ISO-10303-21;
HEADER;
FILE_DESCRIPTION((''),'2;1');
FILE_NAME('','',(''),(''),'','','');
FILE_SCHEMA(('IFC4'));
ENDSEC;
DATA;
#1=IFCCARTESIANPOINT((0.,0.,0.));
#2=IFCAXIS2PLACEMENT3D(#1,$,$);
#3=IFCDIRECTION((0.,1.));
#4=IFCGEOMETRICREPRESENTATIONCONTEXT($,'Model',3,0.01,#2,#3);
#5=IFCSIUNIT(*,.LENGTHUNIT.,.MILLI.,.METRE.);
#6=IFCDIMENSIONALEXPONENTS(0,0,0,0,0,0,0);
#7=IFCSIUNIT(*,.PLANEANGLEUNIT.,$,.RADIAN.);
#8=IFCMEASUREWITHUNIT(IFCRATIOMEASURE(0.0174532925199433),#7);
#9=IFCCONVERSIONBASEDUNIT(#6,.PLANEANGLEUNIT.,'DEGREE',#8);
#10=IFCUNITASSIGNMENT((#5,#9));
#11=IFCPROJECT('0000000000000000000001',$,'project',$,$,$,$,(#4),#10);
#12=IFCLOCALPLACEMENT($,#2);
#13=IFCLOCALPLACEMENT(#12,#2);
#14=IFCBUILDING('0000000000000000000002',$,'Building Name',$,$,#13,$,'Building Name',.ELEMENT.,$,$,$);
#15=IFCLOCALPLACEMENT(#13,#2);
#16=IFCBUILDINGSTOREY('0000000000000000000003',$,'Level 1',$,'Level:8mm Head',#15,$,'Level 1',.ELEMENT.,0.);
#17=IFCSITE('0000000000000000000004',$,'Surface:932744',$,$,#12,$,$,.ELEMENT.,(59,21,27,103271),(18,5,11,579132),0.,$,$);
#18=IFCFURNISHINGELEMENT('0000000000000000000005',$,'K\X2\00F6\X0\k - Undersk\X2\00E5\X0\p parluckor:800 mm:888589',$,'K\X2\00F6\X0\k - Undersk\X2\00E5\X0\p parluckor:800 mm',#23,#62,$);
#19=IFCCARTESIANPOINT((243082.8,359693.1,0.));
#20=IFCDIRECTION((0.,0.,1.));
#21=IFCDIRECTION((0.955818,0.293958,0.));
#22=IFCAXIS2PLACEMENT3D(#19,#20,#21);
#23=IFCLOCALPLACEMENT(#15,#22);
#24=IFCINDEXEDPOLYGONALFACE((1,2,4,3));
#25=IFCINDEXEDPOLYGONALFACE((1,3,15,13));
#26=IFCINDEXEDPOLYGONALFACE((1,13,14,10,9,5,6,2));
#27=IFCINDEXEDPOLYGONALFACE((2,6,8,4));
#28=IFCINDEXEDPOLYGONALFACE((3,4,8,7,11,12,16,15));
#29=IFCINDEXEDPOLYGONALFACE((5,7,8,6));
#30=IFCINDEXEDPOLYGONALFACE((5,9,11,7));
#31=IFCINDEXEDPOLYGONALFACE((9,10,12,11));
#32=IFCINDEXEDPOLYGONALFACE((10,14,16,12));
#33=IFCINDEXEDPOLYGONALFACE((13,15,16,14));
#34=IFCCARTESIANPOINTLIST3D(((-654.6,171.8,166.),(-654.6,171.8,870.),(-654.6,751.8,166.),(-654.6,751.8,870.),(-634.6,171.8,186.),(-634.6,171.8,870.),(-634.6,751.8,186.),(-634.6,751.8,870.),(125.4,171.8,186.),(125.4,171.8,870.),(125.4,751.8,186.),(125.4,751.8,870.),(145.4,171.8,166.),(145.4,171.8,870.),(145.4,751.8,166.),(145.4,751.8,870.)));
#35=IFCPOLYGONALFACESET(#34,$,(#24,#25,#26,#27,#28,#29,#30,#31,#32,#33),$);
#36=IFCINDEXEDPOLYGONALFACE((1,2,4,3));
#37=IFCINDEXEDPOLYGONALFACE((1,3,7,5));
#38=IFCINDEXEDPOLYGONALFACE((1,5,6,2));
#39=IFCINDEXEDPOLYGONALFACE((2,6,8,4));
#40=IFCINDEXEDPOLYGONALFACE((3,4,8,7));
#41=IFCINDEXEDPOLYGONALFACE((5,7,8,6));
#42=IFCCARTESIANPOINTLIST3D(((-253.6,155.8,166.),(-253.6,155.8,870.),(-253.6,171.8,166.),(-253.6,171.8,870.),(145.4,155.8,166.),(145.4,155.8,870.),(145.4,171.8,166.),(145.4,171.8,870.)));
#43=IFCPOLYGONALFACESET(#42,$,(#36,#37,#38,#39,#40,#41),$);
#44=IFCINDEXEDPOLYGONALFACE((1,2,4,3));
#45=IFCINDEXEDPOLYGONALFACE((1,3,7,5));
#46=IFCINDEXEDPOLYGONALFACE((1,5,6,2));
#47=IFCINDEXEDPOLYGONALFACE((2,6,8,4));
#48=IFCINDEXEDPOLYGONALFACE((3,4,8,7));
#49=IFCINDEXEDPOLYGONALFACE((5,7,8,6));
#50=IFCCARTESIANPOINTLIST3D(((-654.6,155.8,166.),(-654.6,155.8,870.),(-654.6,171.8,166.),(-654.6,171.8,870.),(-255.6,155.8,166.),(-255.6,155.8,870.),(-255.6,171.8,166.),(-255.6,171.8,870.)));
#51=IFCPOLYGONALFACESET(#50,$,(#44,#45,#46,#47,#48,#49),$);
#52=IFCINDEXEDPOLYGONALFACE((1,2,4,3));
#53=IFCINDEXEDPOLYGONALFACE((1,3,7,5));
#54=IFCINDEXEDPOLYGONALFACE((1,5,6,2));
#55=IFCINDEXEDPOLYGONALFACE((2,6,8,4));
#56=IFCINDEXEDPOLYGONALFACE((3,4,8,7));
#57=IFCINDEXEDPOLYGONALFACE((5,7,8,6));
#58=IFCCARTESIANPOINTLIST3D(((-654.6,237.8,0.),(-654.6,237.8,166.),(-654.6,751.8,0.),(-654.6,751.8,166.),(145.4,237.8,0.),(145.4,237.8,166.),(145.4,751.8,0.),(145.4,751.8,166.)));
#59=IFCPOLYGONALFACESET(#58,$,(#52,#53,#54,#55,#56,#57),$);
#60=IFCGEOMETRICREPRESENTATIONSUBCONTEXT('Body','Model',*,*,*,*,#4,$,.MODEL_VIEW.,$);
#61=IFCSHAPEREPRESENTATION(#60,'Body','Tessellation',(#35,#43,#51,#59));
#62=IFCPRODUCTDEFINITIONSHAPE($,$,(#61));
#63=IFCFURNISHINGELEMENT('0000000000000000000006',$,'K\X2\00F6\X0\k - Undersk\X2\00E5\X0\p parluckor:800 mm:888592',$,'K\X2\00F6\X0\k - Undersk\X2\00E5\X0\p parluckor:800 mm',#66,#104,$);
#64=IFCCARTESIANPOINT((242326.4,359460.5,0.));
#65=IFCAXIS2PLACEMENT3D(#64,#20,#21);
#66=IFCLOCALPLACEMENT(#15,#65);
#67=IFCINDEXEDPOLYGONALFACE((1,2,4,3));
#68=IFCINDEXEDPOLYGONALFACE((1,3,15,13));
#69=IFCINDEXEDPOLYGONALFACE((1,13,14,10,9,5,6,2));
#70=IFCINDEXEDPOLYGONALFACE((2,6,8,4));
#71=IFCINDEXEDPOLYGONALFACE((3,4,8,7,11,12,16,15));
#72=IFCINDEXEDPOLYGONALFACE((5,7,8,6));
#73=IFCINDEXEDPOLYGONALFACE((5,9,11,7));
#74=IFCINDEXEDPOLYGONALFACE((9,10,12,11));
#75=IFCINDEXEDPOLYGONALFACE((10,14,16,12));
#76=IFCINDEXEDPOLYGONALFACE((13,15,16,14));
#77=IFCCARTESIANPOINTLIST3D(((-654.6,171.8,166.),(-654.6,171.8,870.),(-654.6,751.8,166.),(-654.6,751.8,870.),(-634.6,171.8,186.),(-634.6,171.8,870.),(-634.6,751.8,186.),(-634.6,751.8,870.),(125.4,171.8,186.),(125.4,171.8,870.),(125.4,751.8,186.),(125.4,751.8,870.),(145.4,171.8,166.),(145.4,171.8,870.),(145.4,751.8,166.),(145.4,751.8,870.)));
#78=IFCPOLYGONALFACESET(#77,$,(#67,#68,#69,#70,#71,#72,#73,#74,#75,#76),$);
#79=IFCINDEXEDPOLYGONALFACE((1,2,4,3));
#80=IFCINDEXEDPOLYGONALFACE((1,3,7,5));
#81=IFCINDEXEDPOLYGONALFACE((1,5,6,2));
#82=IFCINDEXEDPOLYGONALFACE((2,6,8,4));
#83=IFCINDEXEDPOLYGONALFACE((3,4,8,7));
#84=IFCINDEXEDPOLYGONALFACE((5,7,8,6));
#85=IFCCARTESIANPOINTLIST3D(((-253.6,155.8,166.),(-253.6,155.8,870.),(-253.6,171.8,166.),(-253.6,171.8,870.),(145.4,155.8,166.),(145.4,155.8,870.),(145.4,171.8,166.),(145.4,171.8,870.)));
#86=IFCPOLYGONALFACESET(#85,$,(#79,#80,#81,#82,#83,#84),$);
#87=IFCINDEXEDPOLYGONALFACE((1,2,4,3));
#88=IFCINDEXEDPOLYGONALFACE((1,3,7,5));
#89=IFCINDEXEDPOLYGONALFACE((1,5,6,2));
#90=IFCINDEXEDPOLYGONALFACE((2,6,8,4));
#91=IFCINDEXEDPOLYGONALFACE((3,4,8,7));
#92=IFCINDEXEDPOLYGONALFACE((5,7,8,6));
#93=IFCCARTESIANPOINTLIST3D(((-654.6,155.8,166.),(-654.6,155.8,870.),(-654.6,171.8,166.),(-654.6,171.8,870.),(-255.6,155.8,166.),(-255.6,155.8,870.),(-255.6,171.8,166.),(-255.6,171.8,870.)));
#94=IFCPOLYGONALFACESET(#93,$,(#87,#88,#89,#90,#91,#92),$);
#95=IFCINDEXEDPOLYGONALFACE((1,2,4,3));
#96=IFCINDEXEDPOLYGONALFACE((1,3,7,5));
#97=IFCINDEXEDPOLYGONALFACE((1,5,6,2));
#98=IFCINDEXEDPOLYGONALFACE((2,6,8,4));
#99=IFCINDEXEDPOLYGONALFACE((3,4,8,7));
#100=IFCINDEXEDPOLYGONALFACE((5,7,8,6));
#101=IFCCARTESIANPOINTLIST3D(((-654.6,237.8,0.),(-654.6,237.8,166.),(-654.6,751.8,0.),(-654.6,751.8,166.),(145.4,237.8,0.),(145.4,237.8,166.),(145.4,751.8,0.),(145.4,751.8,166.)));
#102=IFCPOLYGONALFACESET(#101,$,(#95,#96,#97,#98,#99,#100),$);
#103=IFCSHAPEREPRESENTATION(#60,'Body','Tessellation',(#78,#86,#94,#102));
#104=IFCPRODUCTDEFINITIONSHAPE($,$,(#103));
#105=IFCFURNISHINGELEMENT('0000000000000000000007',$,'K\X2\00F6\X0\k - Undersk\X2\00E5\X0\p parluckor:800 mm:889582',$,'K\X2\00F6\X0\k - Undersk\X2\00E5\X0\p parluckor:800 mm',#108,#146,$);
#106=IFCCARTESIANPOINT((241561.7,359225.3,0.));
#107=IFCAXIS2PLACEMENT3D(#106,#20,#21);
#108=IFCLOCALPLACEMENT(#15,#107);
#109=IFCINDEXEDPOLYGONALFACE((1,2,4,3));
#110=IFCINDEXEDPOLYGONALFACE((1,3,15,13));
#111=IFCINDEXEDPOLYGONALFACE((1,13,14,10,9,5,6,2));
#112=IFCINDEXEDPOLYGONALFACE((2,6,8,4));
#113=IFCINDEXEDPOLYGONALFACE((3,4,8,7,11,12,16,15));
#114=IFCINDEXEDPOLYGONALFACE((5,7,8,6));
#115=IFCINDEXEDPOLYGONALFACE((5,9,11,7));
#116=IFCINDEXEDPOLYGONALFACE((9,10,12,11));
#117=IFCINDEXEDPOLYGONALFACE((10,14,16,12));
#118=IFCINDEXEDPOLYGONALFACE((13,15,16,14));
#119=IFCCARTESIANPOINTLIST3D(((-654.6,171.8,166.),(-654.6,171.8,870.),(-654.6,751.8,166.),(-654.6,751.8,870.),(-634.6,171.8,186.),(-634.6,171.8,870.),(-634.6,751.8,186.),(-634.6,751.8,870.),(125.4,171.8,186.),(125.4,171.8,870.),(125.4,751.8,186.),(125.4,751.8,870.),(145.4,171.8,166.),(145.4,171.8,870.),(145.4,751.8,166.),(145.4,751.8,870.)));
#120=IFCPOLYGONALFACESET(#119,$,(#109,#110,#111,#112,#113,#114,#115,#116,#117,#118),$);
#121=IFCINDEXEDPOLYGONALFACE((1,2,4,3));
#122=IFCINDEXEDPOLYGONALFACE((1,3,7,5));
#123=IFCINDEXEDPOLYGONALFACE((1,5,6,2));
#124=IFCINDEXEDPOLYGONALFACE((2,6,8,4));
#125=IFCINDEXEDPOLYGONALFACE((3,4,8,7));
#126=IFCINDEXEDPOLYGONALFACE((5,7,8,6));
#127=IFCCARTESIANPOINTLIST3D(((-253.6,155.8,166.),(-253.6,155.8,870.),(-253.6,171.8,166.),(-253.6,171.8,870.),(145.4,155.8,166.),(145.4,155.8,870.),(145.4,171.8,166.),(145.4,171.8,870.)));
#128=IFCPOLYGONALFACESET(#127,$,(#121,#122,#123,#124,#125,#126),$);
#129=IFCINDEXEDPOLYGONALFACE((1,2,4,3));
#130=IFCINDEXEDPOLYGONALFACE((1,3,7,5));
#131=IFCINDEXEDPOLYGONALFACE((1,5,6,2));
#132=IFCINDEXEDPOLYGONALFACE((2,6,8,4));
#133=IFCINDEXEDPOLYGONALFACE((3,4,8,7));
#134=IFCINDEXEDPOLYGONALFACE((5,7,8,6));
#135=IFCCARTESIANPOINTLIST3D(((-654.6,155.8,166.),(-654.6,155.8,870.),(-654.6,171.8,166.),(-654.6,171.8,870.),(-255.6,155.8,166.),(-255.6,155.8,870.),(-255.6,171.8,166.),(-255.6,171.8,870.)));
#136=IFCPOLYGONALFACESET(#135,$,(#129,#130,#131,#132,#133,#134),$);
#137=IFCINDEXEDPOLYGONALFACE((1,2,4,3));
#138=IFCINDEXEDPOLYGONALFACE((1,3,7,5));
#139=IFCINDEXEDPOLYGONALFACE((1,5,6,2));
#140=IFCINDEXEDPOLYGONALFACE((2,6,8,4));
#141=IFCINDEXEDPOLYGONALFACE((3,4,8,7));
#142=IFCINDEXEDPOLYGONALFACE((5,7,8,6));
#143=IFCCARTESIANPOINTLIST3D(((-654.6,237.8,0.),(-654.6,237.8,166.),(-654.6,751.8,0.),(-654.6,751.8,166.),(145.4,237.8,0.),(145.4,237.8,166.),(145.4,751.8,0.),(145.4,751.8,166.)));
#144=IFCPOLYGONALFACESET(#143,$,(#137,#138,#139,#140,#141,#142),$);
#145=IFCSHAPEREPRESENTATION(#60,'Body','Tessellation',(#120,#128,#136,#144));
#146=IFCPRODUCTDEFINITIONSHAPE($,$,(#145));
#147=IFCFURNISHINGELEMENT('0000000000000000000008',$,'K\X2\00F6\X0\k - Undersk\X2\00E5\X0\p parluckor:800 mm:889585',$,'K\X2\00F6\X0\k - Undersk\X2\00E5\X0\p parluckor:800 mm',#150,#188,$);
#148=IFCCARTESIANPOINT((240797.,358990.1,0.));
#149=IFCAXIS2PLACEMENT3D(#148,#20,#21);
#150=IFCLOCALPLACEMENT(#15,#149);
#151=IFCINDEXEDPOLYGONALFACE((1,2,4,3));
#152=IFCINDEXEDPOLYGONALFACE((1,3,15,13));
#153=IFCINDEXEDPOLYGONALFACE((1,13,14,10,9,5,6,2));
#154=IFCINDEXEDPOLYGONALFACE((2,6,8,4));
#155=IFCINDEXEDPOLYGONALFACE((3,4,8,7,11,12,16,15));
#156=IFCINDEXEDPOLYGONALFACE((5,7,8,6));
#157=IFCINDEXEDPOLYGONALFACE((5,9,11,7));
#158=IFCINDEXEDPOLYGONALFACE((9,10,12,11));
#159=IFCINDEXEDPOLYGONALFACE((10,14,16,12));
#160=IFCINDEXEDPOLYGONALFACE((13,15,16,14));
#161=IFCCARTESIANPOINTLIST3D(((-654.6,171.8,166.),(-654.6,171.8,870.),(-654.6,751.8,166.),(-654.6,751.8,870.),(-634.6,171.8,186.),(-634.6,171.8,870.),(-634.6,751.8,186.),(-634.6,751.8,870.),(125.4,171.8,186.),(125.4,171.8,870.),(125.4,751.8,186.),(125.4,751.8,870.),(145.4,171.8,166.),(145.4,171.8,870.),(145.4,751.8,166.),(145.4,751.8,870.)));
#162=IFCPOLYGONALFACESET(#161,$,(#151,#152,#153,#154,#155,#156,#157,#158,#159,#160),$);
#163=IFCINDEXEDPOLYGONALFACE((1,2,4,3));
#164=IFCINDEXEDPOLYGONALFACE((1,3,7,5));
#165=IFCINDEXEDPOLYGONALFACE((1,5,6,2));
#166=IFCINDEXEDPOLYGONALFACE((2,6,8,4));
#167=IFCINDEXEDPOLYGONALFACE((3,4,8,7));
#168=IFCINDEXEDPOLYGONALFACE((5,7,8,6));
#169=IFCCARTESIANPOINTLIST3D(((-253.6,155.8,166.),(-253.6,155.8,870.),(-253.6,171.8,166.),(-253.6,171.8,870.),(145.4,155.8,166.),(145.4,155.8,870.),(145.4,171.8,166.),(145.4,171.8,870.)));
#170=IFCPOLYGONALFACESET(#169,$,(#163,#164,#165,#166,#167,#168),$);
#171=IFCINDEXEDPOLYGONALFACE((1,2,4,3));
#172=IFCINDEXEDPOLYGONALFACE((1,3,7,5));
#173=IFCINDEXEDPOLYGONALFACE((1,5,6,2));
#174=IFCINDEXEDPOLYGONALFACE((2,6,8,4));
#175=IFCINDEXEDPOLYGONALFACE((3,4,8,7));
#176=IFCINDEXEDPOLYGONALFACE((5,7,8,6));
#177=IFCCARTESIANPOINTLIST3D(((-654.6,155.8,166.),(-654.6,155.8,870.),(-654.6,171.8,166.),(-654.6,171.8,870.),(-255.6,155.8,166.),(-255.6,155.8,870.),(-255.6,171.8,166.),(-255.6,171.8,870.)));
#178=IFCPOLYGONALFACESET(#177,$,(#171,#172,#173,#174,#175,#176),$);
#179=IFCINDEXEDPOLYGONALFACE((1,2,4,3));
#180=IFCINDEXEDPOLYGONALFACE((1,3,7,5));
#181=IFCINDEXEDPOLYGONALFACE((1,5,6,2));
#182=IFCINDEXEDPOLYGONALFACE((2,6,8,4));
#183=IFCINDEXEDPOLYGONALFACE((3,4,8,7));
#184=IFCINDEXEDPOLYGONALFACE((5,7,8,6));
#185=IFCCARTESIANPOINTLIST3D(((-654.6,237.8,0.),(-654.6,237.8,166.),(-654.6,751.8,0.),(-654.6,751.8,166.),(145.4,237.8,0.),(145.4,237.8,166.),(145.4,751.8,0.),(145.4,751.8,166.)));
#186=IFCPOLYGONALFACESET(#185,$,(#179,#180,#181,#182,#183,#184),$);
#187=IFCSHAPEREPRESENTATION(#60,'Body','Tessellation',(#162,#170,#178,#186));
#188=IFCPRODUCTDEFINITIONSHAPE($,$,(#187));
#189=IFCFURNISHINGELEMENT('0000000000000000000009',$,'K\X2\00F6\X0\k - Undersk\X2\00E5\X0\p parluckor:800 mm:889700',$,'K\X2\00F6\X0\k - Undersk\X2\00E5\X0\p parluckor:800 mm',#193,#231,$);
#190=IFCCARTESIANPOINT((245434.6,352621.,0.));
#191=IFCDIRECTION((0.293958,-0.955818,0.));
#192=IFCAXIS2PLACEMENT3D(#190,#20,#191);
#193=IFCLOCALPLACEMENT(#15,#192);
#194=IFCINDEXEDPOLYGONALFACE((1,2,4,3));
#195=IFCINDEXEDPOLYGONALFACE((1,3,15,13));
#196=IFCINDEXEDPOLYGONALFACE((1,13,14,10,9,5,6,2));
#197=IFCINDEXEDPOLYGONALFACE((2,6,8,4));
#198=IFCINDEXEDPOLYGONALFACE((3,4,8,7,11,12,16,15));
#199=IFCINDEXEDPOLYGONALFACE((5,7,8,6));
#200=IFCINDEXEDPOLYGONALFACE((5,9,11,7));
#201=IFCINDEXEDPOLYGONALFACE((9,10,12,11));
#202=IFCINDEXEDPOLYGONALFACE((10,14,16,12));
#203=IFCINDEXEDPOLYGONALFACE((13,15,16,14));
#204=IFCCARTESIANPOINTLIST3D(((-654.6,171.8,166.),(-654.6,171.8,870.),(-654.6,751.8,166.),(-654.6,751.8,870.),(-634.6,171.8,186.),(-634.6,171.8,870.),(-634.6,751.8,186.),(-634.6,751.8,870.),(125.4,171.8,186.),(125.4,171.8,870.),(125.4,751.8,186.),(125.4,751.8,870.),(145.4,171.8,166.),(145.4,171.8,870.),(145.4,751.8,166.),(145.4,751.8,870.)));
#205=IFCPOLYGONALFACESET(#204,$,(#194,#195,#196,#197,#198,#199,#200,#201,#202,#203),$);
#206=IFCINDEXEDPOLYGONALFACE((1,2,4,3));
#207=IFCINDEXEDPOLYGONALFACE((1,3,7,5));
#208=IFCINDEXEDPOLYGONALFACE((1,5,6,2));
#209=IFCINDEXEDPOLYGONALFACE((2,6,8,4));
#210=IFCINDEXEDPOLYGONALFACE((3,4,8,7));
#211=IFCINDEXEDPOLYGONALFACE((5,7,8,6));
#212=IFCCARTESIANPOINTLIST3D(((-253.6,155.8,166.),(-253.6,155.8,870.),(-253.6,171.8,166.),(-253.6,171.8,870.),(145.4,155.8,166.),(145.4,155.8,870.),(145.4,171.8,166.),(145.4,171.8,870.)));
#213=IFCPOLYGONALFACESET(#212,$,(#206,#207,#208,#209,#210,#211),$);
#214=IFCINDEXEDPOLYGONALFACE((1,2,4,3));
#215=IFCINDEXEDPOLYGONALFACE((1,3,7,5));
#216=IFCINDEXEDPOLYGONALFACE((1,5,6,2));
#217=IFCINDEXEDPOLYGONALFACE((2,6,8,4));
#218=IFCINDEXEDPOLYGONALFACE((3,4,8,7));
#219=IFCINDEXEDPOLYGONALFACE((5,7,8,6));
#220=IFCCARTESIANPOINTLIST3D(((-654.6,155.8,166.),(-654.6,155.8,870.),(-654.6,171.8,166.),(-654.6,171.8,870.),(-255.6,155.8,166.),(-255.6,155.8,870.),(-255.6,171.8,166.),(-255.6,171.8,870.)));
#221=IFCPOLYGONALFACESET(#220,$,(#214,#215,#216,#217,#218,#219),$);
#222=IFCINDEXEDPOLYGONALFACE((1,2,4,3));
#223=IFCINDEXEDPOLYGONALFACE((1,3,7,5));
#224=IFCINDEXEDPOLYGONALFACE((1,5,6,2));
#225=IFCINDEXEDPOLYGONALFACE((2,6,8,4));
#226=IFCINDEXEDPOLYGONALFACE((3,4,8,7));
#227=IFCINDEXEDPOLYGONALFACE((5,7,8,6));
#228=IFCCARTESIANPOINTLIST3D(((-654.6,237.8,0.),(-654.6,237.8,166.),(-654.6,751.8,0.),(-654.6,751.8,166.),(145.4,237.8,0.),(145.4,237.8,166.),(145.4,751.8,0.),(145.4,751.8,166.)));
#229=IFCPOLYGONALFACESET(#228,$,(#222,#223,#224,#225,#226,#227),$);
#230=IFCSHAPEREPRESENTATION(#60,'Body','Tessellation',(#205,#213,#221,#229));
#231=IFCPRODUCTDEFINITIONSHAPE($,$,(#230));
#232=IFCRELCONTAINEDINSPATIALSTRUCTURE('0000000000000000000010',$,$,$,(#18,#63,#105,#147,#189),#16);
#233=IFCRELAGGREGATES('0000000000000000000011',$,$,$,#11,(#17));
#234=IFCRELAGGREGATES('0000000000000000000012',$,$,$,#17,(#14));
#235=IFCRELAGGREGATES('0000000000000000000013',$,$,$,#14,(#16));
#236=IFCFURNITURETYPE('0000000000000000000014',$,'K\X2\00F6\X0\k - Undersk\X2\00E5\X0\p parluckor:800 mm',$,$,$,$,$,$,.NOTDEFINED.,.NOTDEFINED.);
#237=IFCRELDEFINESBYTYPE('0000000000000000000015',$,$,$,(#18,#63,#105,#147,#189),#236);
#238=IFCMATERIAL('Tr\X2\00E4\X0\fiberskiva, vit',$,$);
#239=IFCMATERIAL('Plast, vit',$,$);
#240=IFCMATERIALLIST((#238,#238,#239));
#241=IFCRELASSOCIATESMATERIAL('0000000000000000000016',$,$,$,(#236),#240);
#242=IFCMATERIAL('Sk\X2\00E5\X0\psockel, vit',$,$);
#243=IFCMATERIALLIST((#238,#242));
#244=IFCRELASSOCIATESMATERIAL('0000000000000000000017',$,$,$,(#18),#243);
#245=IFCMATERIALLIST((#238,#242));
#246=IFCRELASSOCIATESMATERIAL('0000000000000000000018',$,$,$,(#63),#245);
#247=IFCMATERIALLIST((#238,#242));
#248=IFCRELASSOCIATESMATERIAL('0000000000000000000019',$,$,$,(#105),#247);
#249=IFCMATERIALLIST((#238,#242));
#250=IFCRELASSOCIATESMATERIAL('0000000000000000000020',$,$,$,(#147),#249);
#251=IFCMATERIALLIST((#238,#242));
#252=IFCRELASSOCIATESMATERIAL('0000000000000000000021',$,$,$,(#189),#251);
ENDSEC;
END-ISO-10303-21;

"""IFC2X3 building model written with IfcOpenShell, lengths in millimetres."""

from ifc_helpers import new_model, entity, si_unit, converted_unit, direction, frame, frame_2d, origin, origin_2d_with_axis, place, context, subcontext, project, spatial, polyline, rectangle, outline, extrude, source, transform, mapped, material, material_list, type_object, type_shapes, element, save


model = new_model("IFC2X3")

# Units and contexts
model_context = context("Model", 3, precision=0.01, world=origin(), true_north=direction((0.0, 1.0)))
body_context = subcontext(model_context, "Body", "Model", "MODEL_VIEW")
ifc_project = project(units=[si_unit("LENGTHUNIT", "METRE", prefix="MILLI"), converted_unit("PLANEANGLEUNIT", "DEGREE", entity("IfcRatioMeasure", 0.0174532925199433), si_unit("PLANEANGLEUNIT", "RADIAN"), dimensions=[0, 0, 0, 0, 0, 0, 0])], contexts=[model_context])

# Site, building, storey
site_placement = place(None, origin())
site = spatial("IfcSite", under=ifc_project, at=site_placement, Name="Surface:932744", CompositionType="ELEMENT", RefLatitude=(59, 21, 27, 103271), RefLongitude=(18, 5, 11, 579132), RefElevation=0.0)
building_placement = place(site_placement, origin())
building = spatial("IfcBuilding", under=site, at=building_placement, Name="Building Name", LongName="Building Name", CompositionType="ELEMENT")
storey_placement = place(building_placement, origin())
storey = spatial("IfcBuildingStorey", under=building, at=storey_placement, Name="Level 1", ObjectType="Level:8mm Head", LongName="Level 1", CompositionType="ELEMENT", Elevation=0.0)

# Furnishing elements
ifc_material_1 = material(Name="Träfiberskiva, vit")
ifc_material_2 = material(Name="Skåpsockel, vit")
ifc_material_list_1 = material_list([ifc_material_1, ifc_material_2])
ifc_material_3 = material(Name="Plast, vit")
ifc_material_list_2 = material_list([ifc_material_1, ifc_material_1, ifc_material_3])
furniture_type_1 = type_object("IfcFurnitureType", Name="Kök - Underskåp parluckor:800 mm", material=ifc_material_list_2)
shared_shape_1 = source(origin(), body_context, "Body", "SweptSolid", [
    extrude(outline(polyline([(-400.0, -347.0), (-380.0, -347.0), (-380.0, 337.0), (380.0, 337.0), (380.0, -347.0), (400.0, -347.0), (400.0, 357.0), (-400.0, 357.0), (-400.0, -347.0)])), frame((-254.6, 171.8, 523.0), z_axis=(0.0, 1.0, 0.0), x_axis=(1.0, 0.0, 0.0)), (0.0, 0.0, 1.0), 580.0),
    extrude(rectangle(XDim=16.0, YDim=399.0, at=frame_2d((0.0, 0.0), x_axis=(1.0, 0.0))), frame((-54.1, 163.8, 166.0), z_axis=(0.0, 0.0, 1.0), x_axis=(0.0, 1.0, 0.0)), (0.0, 0.0, 1.0), 704.0),
    extrude(rectangle(XDim=16.0, YDim=399.0, at=frame_2d((0.0, 0.0), x_axis=(1.0, 0.0))), frame((-455.1, 163.8, 166.0), z_axis=(0.0, 0.0, 1.0), x_axis=(0.0, 1.0, 0.0)), (0.0, 0.0, 1.0), 704.0),
    extrude(rectangle(XDim=800.0, YDim=514.0, at=origin_2d_with_axis()), frame((-254.6, 494.8, 0.0), z_axis=(0.0, 0.0, 1.0), x_axis=(-1.0, 0.0, 0.0)), (0.0, 0.0, 1.0), 166.0),
])
type_shapes(furniture_type_1, [shared_shape_1])
furnishing_1_placement = place(storey_placement, frame((243082.8, 359693.1, 0.0), z_axis=(0.0, 0.0, 1.0), x_axis=(0.955818, 0.293958, 0.0)))
element("IfcFurnishingElement", 1, at=furnishing_1_placement, inside=storey, type_object=furniture_type_1, material=ifc_material_list_1, Name="Kök - Underskåp parluckor:800 mm:888589", ObjectType="Kök - Underskåp parluckor:800 mm", context=body_context, shape_type="MappedRepresentation", body=[
    mapped(shared_shape_1, transform((0.0, 0.0, 0.0), scale=1.0)),
])
ifc_material_list_3 = material_list([ifc_material_1, ifc_material_2])
furnishing_2_placement = place(storey_placement, frame((242326.4, 359460.5, 0.0), z_axis=(0.0, 0.0, 1.0), x_axis=(0.955818, 0.293958, 0.0)))
element("IfcFurnishingElement", 2, at=furnishing_2_placement, inside=storey, type_object=furniture_type_1, material=ifc_material_list_3, Name="Kök - Underskåp parluckor:800 mm:888592", ObjectType="Kök - Underskåp parluckor:800 mm", context=body_context, shape_type="MappedRepresentation", body=[
    mapped(shared_shape_1, transform((0.0, 0.0, 0.0), scale=1.0)),
])
ifc_material_list_4 = material_list([ifc_material_1, ifc_material_2])
furnishing_3_placement = place(storey_placement, frame((241561.7, 359225.3, 0.0), z_axis=(0.0, 0.0, 1.0), x_axis=(0.955818, 0.293958, 0.0)))
element("IfcFurnishingElement", 3, at=furnishing_3_placement, inside=storey, type_object=furniture_type_1, material=ifc_material_list_4, Name="Kök - Underskåp parluckor:800 mm:889582", ObjectType="Kök - Underskåp parluckor:800 mm", context=body_context, shape_type="MappedRepresentation", body=[
    mapped(shared_shape_1, transform((0.0, 0.0, 0.0), scale=1.0)),
])
ifc_material_list_5 = material_list([ifc_material_1, ifc_material_2])
furnishing_4_placement = place(storey_placement, frame((240797.0, 358990.1, 0.0), z_axis=(0.0, 0.0, 1.0), x_axis=(0.955818, 0.293958, 0.0)))
element("IfcFurnishingElement", 4, at=furnishing_4_placement, inside=storey, type_object=furniture_type_1, material=ifc_material_list_5, Name="Kök - Underskåp parluckor:800 mm:889585", ObjectType="Kök - Underskåp parluckor:800 mm", context=body_context, shape_type="MappedRepresentation", body=[
    mapped(shared_shape_1, transform((0.0, 0.0, 0.0), scale=1.0)),
])
ifc_material_list_6 = material_list([ifc_material_1, ifc_material_2])
furnishing_5_placement = place(storey_placement, frame((245434.6, 352621.0, 0.0), z_axis=(0.0, 0.0, 1.0), x_axis=(0.293958, -0.955818, 0.0)))
element("IfcFurnishingElement", 5, at=furnishing_5_placement, inside=storey, type_object=furniture_type_1, material=ifc_material_list_6, Name="Kök - Underskåp parluckor:800 mm:889700", ObjectType="Kök - Underskåp parluckor:800 mm", context=body_context, shape_type="MappedRepresentation", body=[
    mapped(shared_shape_1, transform((0.0, 0.0, 0.0), scale=1.0)),
])

save(model, "model.ifc")
